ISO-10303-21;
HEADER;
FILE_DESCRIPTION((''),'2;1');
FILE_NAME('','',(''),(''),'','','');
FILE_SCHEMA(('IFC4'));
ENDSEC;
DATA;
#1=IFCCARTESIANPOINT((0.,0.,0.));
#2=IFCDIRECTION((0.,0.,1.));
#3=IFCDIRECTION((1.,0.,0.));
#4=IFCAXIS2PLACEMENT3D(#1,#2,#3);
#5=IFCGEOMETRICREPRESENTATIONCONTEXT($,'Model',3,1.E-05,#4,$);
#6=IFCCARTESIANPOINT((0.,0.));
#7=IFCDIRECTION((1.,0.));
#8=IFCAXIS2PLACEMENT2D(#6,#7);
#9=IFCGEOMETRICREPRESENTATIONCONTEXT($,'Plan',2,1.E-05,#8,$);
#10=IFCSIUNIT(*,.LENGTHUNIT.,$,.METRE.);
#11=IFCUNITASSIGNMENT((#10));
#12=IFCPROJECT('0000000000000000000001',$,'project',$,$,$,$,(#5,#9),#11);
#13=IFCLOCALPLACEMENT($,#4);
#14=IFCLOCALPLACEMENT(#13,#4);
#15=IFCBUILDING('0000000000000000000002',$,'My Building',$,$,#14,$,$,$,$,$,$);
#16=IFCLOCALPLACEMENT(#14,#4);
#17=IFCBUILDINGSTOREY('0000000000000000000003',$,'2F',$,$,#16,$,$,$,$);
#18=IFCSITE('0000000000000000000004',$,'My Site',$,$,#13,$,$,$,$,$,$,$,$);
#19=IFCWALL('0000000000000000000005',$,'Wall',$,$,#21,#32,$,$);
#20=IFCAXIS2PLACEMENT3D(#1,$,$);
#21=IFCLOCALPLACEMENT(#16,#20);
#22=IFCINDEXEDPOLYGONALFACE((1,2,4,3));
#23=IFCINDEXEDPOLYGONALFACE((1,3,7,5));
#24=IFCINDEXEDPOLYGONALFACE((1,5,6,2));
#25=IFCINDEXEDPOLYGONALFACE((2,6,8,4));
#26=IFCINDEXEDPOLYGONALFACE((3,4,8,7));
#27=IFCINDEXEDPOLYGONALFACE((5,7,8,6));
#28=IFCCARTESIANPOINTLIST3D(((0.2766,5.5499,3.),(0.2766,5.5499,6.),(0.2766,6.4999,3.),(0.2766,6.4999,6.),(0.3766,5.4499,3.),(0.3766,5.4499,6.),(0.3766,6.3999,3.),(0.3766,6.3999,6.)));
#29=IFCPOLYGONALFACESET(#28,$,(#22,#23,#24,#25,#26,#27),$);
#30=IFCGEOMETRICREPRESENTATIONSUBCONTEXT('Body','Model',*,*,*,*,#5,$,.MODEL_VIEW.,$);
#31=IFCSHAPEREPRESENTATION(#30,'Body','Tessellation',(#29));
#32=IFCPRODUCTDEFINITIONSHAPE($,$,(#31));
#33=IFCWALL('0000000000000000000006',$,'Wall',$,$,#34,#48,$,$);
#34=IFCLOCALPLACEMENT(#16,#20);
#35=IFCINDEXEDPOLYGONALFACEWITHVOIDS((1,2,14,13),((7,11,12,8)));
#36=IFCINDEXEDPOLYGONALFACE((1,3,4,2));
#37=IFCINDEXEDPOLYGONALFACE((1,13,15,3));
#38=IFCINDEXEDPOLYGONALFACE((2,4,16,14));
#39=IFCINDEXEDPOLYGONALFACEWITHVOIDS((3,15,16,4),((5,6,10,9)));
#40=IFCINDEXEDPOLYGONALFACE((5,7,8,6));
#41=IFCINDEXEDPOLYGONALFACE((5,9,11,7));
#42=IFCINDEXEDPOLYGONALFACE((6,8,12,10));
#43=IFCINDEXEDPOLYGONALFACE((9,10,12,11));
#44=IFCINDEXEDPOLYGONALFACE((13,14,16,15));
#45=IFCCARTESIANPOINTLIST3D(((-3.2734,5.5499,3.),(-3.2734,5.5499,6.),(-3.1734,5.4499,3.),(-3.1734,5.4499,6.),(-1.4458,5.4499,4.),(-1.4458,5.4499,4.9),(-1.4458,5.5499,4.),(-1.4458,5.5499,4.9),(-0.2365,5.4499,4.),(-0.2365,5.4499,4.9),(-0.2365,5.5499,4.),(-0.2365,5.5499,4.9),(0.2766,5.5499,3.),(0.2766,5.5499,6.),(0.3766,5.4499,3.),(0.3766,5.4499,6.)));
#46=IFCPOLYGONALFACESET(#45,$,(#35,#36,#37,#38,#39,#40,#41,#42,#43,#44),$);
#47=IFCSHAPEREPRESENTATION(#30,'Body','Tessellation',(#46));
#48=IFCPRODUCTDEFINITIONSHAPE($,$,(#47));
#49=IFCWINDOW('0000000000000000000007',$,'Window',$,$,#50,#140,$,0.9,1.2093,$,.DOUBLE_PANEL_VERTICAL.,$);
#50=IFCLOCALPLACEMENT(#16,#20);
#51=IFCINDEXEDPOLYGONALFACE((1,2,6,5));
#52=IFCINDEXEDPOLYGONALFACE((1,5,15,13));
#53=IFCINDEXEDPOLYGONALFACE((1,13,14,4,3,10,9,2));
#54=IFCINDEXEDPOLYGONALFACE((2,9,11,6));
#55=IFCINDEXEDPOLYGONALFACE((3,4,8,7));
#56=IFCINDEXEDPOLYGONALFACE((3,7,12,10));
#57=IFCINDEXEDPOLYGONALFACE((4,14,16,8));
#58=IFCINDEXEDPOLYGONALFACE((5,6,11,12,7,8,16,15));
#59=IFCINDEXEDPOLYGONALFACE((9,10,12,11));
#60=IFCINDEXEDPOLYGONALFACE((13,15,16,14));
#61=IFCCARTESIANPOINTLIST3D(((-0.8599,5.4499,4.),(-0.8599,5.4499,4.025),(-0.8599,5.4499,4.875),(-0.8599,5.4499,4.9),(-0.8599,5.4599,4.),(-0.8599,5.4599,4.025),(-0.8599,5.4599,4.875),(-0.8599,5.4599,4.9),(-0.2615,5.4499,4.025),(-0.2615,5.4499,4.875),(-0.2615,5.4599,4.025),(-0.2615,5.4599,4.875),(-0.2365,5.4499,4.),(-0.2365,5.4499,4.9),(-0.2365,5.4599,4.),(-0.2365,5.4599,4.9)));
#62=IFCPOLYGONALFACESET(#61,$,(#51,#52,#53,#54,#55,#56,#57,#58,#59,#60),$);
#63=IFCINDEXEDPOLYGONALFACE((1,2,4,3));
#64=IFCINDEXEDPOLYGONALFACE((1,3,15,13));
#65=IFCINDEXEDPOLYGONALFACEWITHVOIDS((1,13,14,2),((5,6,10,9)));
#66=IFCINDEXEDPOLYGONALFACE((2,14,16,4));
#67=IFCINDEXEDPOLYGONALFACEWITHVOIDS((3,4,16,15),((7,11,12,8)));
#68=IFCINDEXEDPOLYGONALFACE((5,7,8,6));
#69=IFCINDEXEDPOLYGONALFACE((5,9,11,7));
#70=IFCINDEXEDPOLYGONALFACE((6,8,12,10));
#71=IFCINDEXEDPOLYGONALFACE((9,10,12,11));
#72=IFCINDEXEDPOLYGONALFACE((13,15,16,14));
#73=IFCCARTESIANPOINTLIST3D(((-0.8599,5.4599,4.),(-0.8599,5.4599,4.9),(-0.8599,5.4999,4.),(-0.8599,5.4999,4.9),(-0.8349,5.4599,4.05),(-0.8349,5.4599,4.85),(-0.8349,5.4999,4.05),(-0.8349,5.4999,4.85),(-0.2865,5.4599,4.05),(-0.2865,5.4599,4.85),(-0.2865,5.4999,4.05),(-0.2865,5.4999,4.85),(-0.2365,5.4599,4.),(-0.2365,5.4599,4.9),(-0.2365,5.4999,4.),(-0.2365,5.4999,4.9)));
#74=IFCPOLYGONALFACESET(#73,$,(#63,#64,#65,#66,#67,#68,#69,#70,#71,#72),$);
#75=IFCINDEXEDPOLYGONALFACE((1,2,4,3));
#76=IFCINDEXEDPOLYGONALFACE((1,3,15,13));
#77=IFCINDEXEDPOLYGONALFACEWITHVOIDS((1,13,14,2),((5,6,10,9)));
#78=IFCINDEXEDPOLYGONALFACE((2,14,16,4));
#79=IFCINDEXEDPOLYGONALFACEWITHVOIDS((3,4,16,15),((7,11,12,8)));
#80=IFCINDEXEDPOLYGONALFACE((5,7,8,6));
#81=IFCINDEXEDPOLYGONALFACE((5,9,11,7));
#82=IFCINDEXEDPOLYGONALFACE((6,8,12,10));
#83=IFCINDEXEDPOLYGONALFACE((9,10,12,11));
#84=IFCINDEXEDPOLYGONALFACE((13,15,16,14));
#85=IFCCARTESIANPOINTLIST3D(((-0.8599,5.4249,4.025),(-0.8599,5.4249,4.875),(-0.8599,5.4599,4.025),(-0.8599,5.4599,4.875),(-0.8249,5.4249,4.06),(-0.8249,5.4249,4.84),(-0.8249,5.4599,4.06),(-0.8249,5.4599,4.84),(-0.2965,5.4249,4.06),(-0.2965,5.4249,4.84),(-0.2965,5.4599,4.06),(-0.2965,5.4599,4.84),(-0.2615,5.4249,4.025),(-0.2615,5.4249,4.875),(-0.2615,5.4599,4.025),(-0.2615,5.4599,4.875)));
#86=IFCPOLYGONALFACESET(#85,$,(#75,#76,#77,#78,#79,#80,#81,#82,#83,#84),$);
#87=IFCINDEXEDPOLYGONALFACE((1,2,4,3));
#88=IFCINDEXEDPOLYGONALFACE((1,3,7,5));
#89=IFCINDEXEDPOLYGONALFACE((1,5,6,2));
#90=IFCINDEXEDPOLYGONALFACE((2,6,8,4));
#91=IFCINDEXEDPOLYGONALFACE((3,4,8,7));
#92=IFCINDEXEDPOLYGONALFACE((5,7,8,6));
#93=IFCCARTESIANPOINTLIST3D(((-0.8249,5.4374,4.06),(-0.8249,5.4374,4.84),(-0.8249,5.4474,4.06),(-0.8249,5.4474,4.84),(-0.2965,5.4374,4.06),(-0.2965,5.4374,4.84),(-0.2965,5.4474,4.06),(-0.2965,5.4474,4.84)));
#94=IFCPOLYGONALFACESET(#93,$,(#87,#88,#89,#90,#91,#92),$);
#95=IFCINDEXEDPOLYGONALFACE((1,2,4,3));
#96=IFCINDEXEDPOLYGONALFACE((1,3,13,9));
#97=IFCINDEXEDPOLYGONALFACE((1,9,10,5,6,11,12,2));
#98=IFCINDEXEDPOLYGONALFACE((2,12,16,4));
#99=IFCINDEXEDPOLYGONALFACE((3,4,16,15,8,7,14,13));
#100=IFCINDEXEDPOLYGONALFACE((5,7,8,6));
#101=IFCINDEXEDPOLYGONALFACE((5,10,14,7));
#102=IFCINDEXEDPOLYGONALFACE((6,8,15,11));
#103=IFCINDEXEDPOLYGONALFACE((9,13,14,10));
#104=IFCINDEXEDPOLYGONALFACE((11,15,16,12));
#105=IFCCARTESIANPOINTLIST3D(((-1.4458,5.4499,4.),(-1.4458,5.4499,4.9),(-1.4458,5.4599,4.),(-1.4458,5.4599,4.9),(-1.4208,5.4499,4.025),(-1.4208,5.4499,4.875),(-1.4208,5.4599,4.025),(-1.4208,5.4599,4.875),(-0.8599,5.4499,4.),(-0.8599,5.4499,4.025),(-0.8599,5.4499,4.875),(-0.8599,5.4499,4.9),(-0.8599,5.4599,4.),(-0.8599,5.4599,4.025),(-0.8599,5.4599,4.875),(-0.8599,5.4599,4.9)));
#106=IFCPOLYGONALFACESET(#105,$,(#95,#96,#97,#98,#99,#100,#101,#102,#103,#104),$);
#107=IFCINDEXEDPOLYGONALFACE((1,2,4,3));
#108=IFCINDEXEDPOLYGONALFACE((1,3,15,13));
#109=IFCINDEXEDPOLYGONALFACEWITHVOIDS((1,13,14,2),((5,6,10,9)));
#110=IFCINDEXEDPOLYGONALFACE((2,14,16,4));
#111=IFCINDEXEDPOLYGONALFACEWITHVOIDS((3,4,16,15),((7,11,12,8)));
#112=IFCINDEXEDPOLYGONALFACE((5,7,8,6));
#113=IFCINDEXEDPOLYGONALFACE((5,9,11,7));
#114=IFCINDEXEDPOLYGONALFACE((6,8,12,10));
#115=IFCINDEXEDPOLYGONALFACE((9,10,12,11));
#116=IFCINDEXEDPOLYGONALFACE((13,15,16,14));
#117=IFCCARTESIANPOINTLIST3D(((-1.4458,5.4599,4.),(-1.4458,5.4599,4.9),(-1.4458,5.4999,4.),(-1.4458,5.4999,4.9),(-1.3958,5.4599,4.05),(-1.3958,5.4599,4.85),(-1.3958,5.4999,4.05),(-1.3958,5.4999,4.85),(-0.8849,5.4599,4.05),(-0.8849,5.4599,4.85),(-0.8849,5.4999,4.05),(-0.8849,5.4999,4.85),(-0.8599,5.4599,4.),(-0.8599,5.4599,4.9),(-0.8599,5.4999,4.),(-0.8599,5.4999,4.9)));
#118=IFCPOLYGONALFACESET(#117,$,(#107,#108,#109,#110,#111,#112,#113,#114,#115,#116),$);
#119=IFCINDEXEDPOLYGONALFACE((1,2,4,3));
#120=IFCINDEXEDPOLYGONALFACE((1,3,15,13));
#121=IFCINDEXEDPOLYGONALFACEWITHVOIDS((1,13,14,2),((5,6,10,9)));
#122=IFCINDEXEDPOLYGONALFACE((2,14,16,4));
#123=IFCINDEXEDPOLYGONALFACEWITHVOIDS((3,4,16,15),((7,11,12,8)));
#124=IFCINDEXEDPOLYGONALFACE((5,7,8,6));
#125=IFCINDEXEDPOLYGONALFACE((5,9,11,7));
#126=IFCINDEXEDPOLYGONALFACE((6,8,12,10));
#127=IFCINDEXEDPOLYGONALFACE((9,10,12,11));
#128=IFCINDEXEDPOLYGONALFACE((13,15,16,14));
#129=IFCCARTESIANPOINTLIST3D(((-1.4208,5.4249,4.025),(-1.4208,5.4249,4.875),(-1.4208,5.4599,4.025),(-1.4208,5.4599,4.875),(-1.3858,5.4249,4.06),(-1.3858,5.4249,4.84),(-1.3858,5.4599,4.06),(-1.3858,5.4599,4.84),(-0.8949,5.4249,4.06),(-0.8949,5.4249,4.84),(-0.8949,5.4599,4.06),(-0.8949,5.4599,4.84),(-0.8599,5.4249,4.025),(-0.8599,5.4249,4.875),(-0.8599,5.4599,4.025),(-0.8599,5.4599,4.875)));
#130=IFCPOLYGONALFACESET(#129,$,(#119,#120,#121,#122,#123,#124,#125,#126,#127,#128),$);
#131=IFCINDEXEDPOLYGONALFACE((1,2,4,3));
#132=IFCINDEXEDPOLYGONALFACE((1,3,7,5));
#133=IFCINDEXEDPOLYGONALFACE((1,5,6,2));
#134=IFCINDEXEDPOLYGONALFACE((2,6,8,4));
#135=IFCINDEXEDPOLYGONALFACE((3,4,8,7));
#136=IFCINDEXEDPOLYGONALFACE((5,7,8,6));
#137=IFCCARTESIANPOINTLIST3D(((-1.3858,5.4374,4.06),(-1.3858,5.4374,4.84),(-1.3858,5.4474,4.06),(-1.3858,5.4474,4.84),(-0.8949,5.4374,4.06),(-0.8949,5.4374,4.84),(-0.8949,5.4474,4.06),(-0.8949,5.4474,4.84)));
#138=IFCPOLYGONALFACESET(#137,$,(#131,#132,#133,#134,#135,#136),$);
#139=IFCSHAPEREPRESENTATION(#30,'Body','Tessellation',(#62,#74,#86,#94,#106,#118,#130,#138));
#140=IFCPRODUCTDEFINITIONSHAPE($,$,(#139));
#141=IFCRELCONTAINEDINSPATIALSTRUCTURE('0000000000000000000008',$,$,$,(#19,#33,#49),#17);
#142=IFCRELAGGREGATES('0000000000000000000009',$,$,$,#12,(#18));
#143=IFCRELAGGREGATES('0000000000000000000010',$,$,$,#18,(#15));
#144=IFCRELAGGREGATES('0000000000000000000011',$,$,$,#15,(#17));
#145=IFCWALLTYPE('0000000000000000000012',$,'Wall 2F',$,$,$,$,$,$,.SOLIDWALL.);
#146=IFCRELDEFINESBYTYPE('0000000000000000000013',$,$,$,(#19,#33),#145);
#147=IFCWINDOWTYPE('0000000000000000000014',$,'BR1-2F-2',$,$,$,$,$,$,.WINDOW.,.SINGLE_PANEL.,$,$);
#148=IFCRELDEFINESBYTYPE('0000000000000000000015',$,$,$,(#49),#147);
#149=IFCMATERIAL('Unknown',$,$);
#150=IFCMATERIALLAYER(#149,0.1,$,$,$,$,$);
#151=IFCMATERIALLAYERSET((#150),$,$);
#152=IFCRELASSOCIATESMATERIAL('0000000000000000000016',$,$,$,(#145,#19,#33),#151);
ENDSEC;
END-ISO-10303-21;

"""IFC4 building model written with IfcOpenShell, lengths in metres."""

from ifc_helpers import new_model, entity, si_unit, frame, origin_with_axes, origin_2d_with_axis, place, context, subcontext, project, spatial, line, indexed_curve, outline, extrude, shape, source, transform, mapped, material, layer, layer_set, layer_usage, type_object, type_shapes, element, fill, save


model = new_model("IFC4")

# Units and contexts
model_context = context("Model", 3, precision=1e-05, world=origin_with_axes())
plan_context = context("Plan", 2, precision=1e-05, world=origin_2d_with_axis())
body_context_1 = subcontext(model_context, "Body", "Model", "MODEL_VIEW")
body_context_2 = subcontext(plan_context, "Body", "Plan", "PLAN_VIEW")
ifc_project = project(units=[si_unit("LENGTHUNIT", "METRE")], contexts=[model_context, plan_context])

# Site, building, storey
site_placement = place(None, origin_with_axes())
site = spatial("IfcSite", under=ifc_project, at=site_placement, Name="My Site")
building_placement = place(site_placement, origin_with_axes())
building = spatial("IfcBuilding", under=site, at=building_placement, Name="My Building")
storey_placement = place(building_placement, origin_with_axes())
storey = spatial("IfcBuildingStorey", under=building, at=storey_placement, Name="2F")

# Shared definitions
ifc_material = material(Name="Unknown")

# Wall
ifc_layer = layer(ifc_material, 0.1)
ifc_layer_set = layer_set([ifc_layer])
wall_type = type_object("IfcWallType", Name="Wall 2F", PredefinedType="SOLIDWALL", material=ifc_layer_set)
ifc_layer_usage_1 = layer_usage(ifc_layer_set, "AXIS2", "POSITIVE", 0.0)
wall_1_placement = place(storey_placement, frame((0.2766, 6.4999, 3.0), z_axis=(0.0, 0.0, 1.0), x_axis=(0.0, -1.0, 0.0)))
element("IfcWall", 1, at=wall_1_placement, inside=storey, type_object=wall_type, material=ifc_layer_usage_1, Name="Wall", context=body_context_1, shape_type="SweptSolid", body=[
    extrude(outline(indexed_curve([(0.0, 0.0), (0.1, 0.1), (1.05, 0.1), (0.95, 0.0)], segments=[line(1, 2, 3, 4, 1)])), origin_with_axes(), (0.0, 0.0, 1.0), 3.0),
])

# Wall, opening, window
ifc_layer_usage_2 = layer_usage(ifc_layer_set, "AXIS2", "POSITIVE", 0.0)
wall_2_placement = place(storey_placement, frame((0.2766, 5.5499, 3.0), z_axis=(0.0, 0.0, 1.0), x_axis=(-1.0, 0.0, 0.0)))
wall_2 = element("IfcWall", 2, at=wall_2_placement, inside=storey, type_object=wall_type, material=ifc_layer_usage_2, Name="Wall", context=body_context_1, shape_type="SweptSolid", body=[
    extrude(outline(indexed_curve([(0.0, 0.0), (-0.1, 0.1), (3.45, 0.1), (3.55, 0.0)], segments=[line(1, 2, 3, 4, 1)])), origin_with_axes(), (0.0, 0.0, 1.0), 3.0),
])
shared_shape_1 = source(origin_with_axes(), body_context_1, "Body", "SweptSolid", [
    extrude(outline(indexed_curve([(0.0, 0.0), (1.2093, 0.0), (1.2093, 0.9), (0.0, 0.9)], segments=[line(1, 2, 3, 4, 1)])), frame((0.0, -0.6, 0.0), z_axis=(0.0, -1.0, 0.0), x_axis=(1.0, 0.0, 0.0)), (0.0, 0.0, -1.0), 1.2),
])
opening_1_placement = place(wall_2_placement, frame((0.5131, 0.0, 1.0), z_axis=(0.0, 0.0, 1.0), x_axis=(1.0, 0.0, 0.0)))
opening_1 = element("IfcOpeningElement", 3, at=opening_1_placement, cuts=wall_2, PredefinedType="OPENING", context=body_context_1, shape_type="MappedRepresentation", body=[
    mapped(shared_shape_1, transform((0.0, 0.0, 0.0), x_axis=(1.0, 0.0, 0.0), y_axis=(0.0, 1.0, 0.0), z_axis=(0.0, 0.0, 1.0), scale=1.0)),
])
window_type_1 = type_object("IfcWindowType", Name="BR1-2F-2", PartitioningType="SINGLE_PANEL", PredefinedType="WINDOW")
shared_shape_2 = source(origin_with_axes(), body_context_1, "Body", "SweptSolid", [
    extrude(outline(indexed_curve([(0.6234, 0.0), (0.0, 0.0), (0.0, 0.9), (0.6234, 0.9), (0.6234, 0.875), (0.025, 0.875), (0.025, 0.025), (0.6234, 0.025)], segments=[line(1, 2, 3, 4, 5, 6, 7, 8, 1)])), frame((0.0, 0.09, 0.0), z_axis=(0.0, -1.0, 0.0), x_axis=(1.0, 0.0, 0.0)), (0.0, 0.0, -1.0), 0.01),
    extrude(outline(indexed_curve([(0.0, 0.0), (0.6234, 0.0), (0.6234, 0.9), (0.0, 0.9)], segments=[line(1, 2, 3, 4, 1)]), holes=[indexed_curve([(0.05, 0.05), (0.5984, 0.05), (0.5984, 0.85), (0.05, 0.85)], segments=[line(1, 2, 3, 4, 1)])]), frame((0.0, 0.05, 0.0), z_axis=(0.0, -1.0, 0.0), x_axis=(1.0, 0.0, 0.0)), (0.0, 0.0, -1.0), 0.04),
    extrude(outline(indexed_curve([(0.0, 0.0), (0.5984, 0.0), (0.5984, 0.85), (0.0, 0.85)], segments=[line(1, 2, 3, 4, 1)]), holes=[indexed_curve([(0.035, 0.035), (0.5634, 0.035), (0.5634, 0.815), (0.035, 0.815)], segments=[line(1, 2, 3, 4, 1)])]), frame((0.025, 0.09, 0.025), z_axis=(0.0, -1.0, 0.0), x_axis=(1.0, 0.0, 0.0)), (0.0, 0.0, -1.0), 0.035),
    extrude(outline(indexed_curve([(0.035, 0.035), (0.5634, 0.035), (0.5634, 0.815), (0.035, 0.815)], segments=[line(1, 2, 3, 4, 1)])), frame((0.025, 0.1025, 0.025), z_axis=(0.0, -1.0, 0.0), x_axis=(1.0, 0.0, 0.0)), (0.0, 0.0, -1.0), 0.01),
    extrude(outline(indexed_curve([(0.0, 0.9), (0.5859, 0.9), (0.5859, 0.0), (0.0, 0.0), (0.0, 0.025), (0.5609, 0.025), (0.5609, 0.875), (0.0, 0.875)], segments=[line(1, 2, 3, 4, 5, 6, 7, 8, 1)])), frame((0.6234, 0.09, 0.0), z_axis=(0.0, -1.0, 0.0), x_axis=(1.0, 0.0, 0.0)), (0.0, 0.0, -1.0), 0.01),
    extrude(outline(indexed_curve([(0.0, 0.0), (0.5859, 0.0), (0.5859, 0.9), (0.0, 0.9)], segments=[line(1, 2, 3, 4, 1)]), holes=[indexed_curve([(0.025, 0.05), (0.5359, 0.05), (0.5359, 0.85), (0.025, 0.85)], segments=[line(1, 2, 3, 4, 1)])]), frame((0.6234, 0.05, 0.0), z_axis=(0.0, -1.0, 0.0), x_axis=(1.0, 0.0, 0.0)), (0.0, 0.0, -1.0), 0.04),
    extrude(outline(indexed_curve([(0.0, 0.0), (0.5609, 0.0), (0.5609, 0.85), (0.0, 0.85)], segments=[line(1, 2, 3, 4, 1)]), holes=[indexed_curve([(0.035, 0.035), (0.5259, 0.035), (0.5259, 0.815), (0.035, 0.815)], segments=[line(1, 2, 3, 4, 1)])]), frame((0.6234, 0.09, 0.025), z_axis=(0.0, -1.0, 0.0), x_axis=(1.0, 0.0, 0.0)), (0.0, 0.0, -1.0), 0.035),
    extrude(outline(indexed_curve([(0.035, 0.035), (0.5259, 0.035), (0.5259, 0.815), (0.035, 0.815)], segments=[line(1, 2, 3, 4, 1)])), frame((0.6234, 0.1025, 0.025), z_axis=(0.0, -1.0, 0.0), x_axis=(1.0, 0.0, 0.0)), (0.0, 0.0, -1.0), 0.01),
])
shared_shape_3 = source(origin_with_axes(), body_context_2, "Body", "Curve2D", [
    entity("IfcIndexedPolyCurve", entity("IfcCartesianPointList2D", [[0.05, 0.05], [0.5984, 0.05]])),
    entity("IfcIndexedPolyCurve", entity("IfcCartesianPointList2D", [[0.0, 0.1], [0.025, 0.1], [0.025, 0.09], [0.05, 0.09], [0.05, 0.05], [0.0, 0.05]]), [entity("IfcLineIndex", [1, 2, 3, 4, 5, 6, 1])]),
    entity("IfcIndexedPolyCurve", entity("IfcCartesianPointList2D", [[0.6234, 0.1], [0.6234, 0.1], [0.6234, 0.09], [0.5984, 0.09], [0.5984, 0.05], [0.6234, 0.05]])),
    entity("IfcIndexedPolyCurve", entity("IfcCartesianPointList2D", [[0.025, 0.09], [0.06, 0.09], [0.06, 0.125], [0.025, 0.125]]), [entity("IfcLineIndex", [1, 2, 3, 4, 1])]),
    entity("IfcIndexedPolyCurve", entity("IfcCartesianPointList2D", [[0.6234, 0.09], [0.5884, 0.09], [0.5884, 0.125], [0.6234, 0.125]]), [entity("IfcLineIndex", [1, 2, 3, 4, 1])]),
    entity("IfcIndexedPolyCurve", entity("IfcCartesianPointList2D", [[0.06, 0.09], [0.5884, 0.09]])),
    entity("IfcIndexedPolyCurve", entity("IfcCartesianPointList2D", [[0.06, 0.125], [0.5884, 0.125]])),
    entity("IfcIndexedPolyCurve", entity("IfcCartesianPointList2D", [[0.06, 0.1075], [0.5884, 0.1075]])),
    entity("IfcIndexedPolyCurve", entity("IfcCartesianPointList2D", [[0.6484, 0.05], [1.1593, 0.05]])),
    entity("IfcIndexedPolyCurve", entity("IfcCartesianPointList2D", [[0.6234, 0.1], [0.6234, 0.1], [0.6234, 0.09], [0.6484, 0.09], [0.6484, 0.05], [0.6234, 0.05]])),
    entity("IfcIndexedPolyCurve", entity("IfcCartesianPointList2D", [[1.2093, 0.1], [1.1843, 0.1], [1.1843, 0.09], [1.1593, 0.09], [1.1593, 0.05], [1.2093, 0.05]]), [entity("IfcLineIndex", [1, 2, 3, 4, 5, 6, 1])]),
    entity("IfcIndexedPolyCurve", entity("IfcCartesianPointList2D", [[0.6234, 0.09], [0.6584, 0.09], [0.6584, 0.125], [0.6234, 0.125]]), [entity("IfcLineIndex", [1, 2, 3, 4, 1])]),
    entity("IfcIndexedPolyCurve", entity("IfcCartesianPointList2D", [[1.1843, 0.09], [1.1493, 0.09], [1.1493, 0.125], [1.1843, 0.125]]), [entity("IfcLineIndex", [1, 2, 3, 4, 1])]),
    entity("IfcIndexedPolyCurve", entity("IfcCartesianPointList2D", [[0.6584, 0.09], [1.1493, 0.09]])),
    entity("IfcIndexedPolyCurve", entity("IfcCartesianPointList2D", [[0.6584, 0.125], [1.1493, 0.125]])),
    entity("IfcIndexedPolyCurve", entity("IfcCartesianPointList2D", [[0.6584, 0.1075], [1.1493, 0.1075]])),
])
type_shapes(window_type_1, [shared_shape_2, shared_shape_3])
window_1_placement = place(opening_1_placement, frame((0.0, 0.0, 0.0), z_axis=(0.0, 0.0, 1.0), x_axis=(1.0, 0.0, 0.0)))
window_1 = element("IfcWindow", 4, at=window_1_placement, inside=storey, type_object=window_type_1, Name="Window", OverallHeight=0.9, OverallWidth=1.2093, PartitioningType="DOUBLE_PANEL_VERTICAL", shapes=[
    shape(body_context_1, "Body", "MappedRepresentation", [mapped(shared_shape_2, transform((0.0, 0.0, 0.0), x_axis=(1.0, 0.0, 0.0), y_axis=(0.0, 1.0, 0.0), z_axis=(0.0, 0.0, 1.0), scale=1.0))]),
    shape(body_context_2, "Body", "MappedRepresentation", [mapped(shared_shape_3, transform((0.0, 0.0, 0.0), x_axis=(1.0, 0.0, 0.0), y_axis=(0.0, 1.0, 0.0), z_axis=(0.0, 0.0, 1.0), scale=1.0))]),
])
fill(opening_1, window_1)

save(model, "model.ifc")
